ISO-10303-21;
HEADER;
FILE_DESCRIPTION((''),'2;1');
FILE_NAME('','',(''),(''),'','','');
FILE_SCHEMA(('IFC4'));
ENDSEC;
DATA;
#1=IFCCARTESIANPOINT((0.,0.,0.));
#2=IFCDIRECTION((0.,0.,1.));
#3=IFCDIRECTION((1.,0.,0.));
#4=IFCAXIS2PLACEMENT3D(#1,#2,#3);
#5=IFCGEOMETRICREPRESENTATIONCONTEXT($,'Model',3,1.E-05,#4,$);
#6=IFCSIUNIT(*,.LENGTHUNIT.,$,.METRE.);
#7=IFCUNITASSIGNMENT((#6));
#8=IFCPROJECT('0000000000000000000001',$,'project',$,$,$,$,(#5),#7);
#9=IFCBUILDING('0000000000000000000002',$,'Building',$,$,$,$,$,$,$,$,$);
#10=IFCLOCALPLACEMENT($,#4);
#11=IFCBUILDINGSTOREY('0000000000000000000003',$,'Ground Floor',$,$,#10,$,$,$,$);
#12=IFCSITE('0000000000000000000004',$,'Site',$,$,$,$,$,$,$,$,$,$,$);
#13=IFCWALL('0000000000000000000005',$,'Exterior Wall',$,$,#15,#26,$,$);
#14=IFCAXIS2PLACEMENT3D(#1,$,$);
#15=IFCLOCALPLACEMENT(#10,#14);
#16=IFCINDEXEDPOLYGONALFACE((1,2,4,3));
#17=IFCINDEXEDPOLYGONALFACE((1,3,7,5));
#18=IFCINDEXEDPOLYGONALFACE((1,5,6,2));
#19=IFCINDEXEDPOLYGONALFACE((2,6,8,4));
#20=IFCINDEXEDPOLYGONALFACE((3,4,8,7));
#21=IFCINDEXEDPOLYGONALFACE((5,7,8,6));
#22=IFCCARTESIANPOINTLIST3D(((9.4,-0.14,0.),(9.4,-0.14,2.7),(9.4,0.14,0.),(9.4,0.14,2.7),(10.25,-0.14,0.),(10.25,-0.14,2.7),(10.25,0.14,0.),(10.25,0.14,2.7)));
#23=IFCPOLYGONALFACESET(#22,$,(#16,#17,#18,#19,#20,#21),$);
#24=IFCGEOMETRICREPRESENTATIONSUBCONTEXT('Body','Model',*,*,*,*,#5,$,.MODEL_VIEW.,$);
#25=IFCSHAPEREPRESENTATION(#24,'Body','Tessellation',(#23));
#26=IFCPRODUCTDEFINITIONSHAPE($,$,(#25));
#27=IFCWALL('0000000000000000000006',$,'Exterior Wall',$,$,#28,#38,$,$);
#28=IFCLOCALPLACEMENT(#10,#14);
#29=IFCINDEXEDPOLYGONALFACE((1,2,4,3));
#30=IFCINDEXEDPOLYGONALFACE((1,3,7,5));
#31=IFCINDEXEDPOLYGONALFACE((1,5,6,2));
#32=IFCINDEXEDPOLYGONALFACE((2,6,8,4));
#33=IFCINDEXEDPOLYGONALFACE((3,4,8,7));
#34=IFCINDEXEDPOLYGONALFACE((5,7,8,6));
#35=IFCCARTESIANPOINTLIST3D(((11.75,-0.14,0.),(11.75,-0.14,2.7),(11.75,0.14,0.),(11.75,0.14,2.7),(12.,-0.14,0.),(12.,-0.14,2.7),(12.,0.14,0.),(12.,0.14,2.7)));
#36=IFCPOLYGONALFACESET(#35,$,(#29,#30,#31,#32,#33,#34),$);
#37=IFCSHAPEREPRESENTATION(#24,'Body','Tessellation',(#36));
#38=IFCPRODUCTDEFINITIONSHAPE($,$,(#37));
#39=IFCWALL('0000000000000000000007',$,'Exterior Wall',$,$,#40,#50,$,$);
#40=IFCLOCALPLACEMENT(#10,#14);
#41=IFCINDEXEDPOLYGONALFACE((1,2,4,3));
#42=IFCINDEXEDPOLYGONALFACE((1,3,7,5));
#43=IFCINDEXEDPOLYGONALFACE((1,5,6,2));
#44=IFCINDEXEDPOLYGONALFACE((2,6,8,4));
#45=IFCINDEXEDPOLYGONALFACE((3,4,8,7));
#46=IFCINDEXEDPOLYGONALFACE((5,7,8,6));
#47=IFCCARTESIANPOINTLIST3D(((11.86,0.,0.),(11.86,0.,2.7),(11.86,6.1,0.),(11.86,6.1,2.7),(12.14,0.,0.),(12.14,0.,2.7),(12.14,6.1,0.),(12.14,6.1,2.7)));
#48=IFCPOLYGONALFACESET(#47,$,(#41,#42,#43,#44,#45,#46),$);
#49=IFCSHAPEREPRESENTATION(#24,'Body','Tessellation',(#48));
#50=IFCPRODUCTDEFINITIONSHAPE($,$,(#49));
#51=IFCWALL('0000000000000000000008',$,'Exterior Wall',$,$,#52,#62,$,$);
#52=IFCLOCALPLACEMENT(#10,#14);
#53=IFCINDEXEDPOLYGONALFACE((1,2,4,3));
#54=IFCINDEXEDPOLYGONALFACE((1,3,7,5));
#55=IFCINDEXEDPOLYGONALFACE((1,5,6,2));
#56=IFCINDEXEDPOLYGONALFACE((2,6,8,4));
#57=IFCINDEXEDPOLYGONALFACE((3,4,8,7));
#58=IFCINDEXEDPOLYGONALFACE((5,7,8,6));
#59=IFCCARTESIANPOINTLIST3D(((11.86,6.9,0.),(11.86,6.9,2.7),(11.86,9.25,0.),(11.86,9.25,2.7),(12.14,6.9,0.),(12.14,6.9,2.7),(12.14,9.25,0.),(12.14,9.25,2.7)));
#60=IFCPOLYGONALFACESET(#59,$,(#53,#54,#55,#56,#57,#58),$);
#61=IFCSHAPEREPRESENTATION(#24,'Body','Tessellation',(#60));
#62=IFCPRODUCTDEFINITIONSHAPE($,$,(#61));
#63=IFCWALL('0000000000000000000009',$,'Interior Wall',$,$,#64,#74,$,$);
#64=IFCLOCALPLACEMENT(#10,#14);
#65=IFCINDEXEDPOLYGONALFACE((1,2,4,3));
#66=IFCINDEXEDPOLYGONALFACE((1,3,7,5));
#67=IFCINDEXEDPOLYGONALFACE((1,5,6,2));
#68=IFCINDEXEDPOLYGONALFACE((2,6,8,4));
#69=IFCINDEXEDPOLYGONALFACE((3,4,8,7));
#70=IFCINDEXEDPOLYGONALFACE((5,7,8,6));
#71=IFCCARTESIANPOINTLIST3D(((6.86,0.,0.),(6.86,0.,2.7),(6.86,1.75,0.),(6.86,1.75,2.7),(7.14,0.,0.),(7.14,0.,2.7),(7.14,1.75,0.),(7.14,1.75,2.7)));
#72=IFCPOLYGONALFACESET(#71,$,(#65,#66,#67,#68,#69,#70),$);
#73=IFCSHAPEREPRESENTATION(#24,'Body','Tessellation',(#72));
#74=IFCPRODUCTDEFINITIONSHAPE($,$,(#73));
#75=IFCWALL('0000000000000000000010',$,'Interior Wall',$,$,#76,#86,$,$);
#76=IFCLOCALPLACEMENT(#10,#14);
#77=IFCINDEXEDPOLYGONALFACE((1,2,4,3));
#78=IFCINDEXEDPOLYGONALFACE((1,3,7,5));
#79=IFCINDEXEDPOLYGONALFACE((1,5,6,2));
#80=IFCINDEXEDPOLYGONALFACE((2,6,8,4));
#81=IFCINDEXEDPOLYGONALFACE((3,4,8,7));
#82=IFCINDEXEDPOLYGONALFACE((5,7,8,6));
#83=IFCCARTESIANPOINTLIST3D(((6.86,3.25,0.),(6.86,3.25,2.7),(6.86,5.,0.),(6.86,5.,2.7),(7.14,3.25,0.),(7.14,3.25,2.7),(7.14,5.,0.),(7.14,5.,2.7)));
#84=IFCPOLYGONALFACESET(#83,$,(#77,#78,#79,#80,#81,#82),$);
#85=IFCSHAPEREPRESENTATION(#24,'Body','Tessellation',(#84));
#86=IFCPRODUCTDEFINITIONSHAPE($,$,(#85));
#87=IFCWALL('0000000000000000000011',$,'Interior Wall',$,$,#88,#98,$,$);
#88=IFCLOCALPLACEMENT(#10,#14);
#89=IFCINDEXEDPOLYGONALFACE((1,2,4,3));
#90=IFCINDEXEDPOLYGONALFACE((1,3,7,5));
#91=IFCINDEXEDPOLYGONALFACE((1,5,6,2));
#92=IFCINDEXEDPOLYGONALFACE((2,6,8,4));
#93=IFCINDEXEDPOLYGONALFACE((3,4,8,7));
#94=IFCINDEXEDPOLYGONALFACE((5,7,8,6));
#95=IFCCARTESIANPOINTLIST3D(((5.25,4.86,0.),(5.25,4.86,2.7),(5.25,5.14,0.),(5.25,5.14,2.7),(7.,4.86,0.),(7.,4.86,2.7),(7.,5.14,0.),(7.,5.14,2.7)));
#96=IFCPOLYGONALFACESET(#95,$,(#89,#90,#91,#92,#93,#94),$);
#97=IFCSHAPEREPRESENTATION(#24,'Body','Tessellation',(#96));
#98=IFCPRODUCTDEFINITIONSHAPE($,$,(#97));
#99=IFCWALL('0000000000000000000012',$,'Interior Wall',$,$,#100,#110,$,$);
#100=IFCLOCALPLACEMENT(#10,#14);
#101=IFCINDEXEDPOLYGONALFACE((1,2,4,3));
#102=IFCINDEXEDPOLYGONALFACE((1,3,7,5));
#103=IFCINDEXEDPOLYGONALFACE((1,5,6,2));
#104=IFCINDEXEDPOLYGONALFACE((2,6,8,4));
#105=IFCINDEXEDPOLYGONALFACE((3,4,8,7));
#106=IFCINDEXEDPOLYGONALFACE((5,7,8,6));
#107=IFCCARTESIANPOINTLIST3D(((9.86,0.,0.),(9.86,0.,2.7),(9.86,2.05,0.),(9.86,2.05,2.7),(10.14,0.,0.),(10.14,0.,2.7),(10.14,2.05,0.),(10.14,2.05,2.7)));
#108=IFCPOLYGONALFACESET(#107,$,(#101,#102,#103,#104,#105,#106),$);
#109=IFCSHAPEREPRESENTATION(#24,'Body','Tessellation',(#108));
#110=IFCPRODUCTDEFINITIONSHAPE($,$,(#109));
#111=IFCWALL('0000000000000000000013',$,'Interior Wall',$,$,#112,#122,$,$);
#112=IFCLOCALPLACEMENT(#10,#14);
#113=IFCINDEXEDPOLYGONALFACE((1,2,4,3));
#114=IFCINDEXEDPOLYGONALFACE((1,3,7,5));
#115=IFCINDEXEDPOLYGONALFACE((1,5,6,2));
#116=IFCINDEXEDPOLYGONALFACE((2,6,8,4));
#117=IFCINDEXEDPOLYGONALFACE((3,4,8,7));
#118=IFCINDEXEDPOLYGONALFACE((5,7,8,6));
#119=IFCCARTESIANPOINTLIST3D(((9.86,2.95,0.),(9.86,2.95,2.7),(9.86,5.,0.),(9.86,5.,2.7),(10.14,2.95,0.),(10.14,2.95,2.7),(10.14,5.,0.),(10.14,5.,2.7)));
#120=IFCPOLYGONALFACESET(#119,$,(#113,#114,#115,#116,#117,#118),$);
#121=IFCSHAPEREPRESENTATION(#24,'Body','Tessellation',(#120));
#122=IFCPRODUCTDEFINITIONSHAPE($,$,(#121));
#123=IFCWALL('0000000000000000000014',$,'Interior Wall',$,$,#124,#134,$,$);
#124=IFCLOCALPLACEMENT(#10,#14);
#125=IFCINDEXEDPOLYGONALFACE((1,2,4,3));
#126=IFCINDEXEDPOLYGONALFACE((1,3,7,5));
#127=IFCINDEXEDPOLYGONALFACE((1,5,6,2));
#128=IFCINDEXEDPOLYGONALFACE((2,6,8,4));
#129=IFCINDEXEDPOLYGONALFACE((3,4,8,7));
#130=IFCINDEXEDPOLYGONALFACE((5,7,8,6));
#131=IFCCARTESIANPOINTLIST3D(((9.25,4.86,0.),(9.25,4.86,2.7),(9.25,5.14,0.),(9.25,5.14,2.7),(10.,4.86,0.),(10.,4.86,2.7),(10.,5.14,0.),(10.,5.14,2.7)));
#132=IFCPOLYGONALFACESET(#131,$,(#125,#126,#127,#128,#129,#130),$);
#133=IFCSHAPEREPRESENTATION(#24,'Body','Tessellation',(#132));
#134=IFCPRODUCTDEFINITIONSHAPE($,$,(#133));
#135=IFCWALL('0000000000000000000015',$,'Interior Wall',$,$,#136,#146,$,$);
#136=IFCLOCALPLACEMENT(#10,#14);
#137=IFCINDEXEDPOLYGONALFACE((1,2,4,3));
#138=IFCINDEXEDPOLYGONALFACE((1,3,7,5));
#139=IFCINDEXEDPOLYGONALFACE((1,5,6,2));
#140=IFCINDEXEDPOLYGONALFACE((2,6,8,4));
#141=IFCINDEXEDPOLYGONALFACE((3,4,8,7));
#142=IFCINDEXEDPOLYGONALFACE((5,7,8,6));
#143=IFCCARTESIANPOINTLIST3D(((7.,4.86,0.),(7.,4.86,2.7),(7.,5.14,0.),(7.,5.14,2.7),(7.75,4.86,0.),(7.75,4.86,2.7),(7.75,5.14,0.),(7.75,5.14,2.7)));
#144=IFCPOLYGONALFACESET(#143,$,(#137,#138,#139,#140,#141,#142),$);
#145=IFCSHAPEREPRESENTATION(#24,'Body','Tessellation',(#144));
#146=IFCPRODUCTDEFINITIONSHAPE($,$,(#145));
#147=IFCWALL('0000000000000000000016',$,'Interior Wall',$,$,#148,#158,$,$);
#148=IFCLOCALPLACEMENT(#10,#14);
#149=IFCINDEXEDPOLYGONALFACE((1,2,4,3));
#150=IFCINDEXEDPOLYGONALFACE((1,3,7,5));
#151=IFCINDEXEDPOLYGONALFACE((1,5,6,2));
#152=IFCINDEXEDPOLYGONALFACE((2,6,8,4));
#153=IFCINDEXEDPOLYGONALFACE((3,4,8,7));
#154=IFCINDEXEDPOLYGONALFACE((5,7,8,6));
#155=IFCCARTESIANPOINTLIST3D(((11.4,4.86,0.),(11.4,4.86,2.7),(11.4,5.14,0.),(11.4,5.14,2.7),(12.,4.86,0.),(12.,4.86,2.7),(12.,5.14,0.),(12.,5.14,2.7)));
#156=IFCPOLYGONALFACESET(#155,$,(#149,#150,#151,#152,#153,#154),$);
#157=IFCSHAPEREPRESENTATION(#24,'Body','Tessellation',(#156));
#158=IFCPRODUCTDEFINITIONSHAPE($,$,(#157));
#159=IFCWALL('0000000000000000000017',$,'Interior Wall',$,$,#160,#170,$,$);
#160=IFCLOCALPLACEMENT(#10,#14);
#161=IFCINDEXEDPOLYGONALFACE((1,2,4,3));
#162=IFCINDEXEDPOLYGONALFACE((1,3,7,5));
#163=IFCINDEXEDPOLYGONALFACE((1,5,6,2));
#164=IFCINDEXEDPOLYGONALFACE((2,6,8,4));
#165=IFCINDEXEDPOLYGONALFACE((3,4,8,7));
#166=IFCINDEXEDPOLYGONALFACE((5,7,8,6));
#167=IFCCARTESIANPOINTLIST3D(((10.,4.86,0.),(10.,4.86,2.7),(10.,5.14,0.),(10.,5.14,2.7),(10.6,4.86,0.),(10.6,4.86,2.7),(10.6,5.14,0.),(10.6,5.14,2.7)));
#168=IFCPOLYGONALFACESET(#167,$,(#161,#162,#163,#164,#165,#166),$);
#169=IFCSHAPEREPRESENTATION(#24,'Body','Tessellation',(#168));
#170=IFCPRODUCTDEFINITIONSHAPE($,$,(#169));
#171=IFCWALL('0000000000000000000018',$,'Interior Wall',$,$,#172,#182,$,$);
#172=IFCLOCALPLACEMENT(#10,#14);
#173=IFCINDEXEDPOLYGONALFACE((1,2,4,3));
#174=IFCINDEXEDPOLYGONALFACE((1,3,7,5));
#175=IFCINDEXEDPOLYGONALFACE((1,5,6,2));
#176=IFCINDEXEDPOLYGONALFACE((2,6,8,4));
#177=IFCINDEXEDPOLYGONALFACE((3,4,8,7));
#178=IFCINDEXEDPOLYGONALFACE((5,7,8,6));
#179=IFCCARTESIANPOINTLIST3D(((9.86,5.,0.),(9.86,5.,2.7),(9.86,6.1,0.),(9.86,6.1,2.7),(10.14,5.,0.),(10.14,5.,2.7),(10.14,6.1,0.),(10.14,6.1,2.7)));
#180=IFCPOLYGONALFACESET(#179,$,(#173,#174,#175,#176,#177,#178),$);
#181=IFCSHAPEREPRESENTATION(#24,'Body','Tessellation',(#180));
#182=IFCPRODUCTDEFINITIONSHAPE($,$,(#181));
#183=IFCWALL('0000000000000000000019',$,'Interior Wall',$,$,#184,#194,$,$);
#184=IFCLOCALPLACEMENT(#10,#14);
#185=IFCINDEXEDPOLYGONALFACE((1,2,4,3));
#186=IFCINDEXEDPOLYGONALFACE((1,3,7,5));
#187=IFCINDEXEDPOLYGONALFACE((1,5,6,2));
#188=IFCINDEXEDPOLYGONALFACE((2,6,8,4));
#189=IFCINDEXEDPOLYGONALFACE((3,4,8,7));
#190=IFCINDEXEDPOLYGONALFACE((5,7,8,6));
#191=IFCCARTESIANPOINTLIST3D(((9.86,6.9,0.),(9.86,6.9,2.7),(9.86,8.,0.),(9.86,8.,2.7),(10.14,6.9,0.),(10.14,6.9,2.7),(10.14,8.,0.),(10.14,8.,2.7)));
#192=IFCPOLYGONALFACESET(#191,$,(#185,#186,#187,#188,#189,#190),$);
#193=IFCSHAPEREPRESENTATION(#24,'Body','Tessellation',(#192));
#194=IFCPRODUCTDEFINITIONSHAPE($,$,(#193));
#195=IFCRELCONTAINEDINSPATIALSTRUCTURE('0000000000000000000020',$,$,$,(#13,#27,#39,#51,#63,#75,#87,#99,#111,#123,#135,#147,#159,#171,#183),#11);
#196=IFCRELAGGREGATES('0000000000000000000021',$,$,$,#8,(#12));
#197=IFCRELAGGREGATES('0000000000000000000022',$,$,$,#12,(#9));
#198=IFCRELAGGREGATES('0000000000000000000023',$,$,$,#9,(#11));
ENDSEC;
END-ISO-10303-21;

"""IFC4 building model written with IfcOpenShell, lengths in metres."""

from ifc_helpers import new_model, si_unit, frame, origin_with_axes, place, context, subcontext, project, spatial, indexed_curve, outline, extrude, element, save


model = new_model("IFC4")

# Units and contexts
model_context = context("Model", 3, precision=1e-05, world=origin_with_axes())
body_context = subcontext(model_context, "Body", "Model", "MODEL_VIEW")
ifc_project = project(units=[si_unit("LENGTHUNIT", "METRE")], contexts=[model_context])

# Site, building, storey
site = spatial("IfcSite", under=ifc_project, Name="Site")
building = spatial("IfcBuilding", under=site, Name="Building")
storey_placement = place(None, origin_with_axes())
storey = spatial("IfcBuildingStorey", under=building, at=storey_placement, Name="Ground Floor")

# Walls
wall_1_placement = place(storey_placement, frame((9.4, 0.0, 0.0), z_axis=(0.0, 0.0, 1.0), x_axis=(1.0, 0.0, 0.0)))
element("IfcWall", 1, at=wall_1_placement, inside=storey, Name="Exterior Wall", context=body_context, shape_type="SweptSolid", body=[
    extrude(outline(indexed_curve([(0.0, 0.0), (0.0, 0.28), (0.85, 0.28), (0.85, 0.0), (0.0, 0.0)], self_intersect=False)), frame((0.0, -0.14, 0.0), z_axis=(0.0, 0.0, 1.0), x_axis=(1.0, 0.0, 0.0)), (0.0, 0.0, 1.0), 2.7),
])
wall_2_placement = place(storey_placement, frame((11.75, 0.0, 0.0), z_axis=(0.0, 0.0, 1.0), x_axis=(1.0, 0.0, 0.0)))
element("IfcWall", 2, at=wall_2_placement, inside=storey, Name="Exterior Wall", context=body_context, shape_type="SweptSolid", body=[
    extrude(outline(indexed_curve([(0.0, 0.0), (0.0, 0.28), (0.25, 0.28), (0.25, 0.0), (0.0, 0.0)], self_intersect=False)), frame((0.0, -0.14, 0.0), z_axis=(0.0, 0.0, 1.0), x_axis=(1.0, 0.0, 0.0)), (0.0, 0.0, 1.0), 2.7),
])
wall_3_placement = place(storey_placement, frame((12.0, 0.0, 0.0), z_axis=(0.0, 0.0, 1.0), x_axis=(0.0, 1.0, 0.0)))
element("IfcWall", 3, at=wall_3_placement, inside=storey, Name="Exterior Wall", context=body_context, shape_type="SweptSolid", body=[
    extrude(outline(indexed_curve([(0.0, 0.0), (0.0, 0.28), (6.1, 0.28), (6.1, 0.0), (0.0, 0.0)], self_intersect=False)), frame((0.0, -0.14, 0.0), z_axis=(0.0, 0.0, 1.0), x_axis=(1.0, 0.0, 0.0)), (0.0, 0.0, 1.0), 2.7),
])
wall_4_placement = place(storey_placement, frame((12.0, 6.9, 0.0), z_axis=(0.0, 0.0, 1.0), x_axis=(0.0, 1.0, 0.0)))
element("IfcWall", 4, at=wall_4_placement, inside=storey, Name="Exterior Wall", context=body_context, shape_type="SweptSolid", body=[
    extrude(outline(indexed_curve([(0.0, 0.0), (0.0, 0.28), (2.35, 0.28), (2.35, 0.0), (0.0, 0.0)], self_intersect=False)), frame((0.0, -0.14, 0.0), z_axis=(0.0, 0.0, 1.0), x_axis=(1.0, 0.0, 0.0)), (0.0, 0.0, 1.0), 2.7),
])
for number, where, z_axis, x_axis, name in (
    (5, (7.0, 0.0, 0.0), (0.0, 0.0, 1.0), (0.0, 1.0, 0.0), "Interior Wall"),
    (6, (7.0, 3.25, 0.0), (0.0, 0.0, 1.0), (0.0, 1.0, 0.0), "Interior Wall"),
    (7, (7.0, 5.0, 0.0), (0.0, 0.0, 1.0), (-1.0, 0.0, 0.0), "Interior Wall"),
):
    element("IfcWall", number, at=place(storey_placement, frame(where, z_axis=z_axis, x_axis=x_axis)), inside=storey, Name=name, context=body_context, shape_type="SweptSolid", body=[
        extrude(outline(indexed_curve([(0.0, 0.0), (0.0, 0.28), (1.75, 0.28), (1.75, 0.0), (0.0, 0.0)], self_intersect=False)), frame((0.0, -0.14, 0.0), z_axis=(0.0, 0.0, 1.0), x_axis=(1.0, 0.0, 0.0)), (0.0, 0.0, 1.0), 2.7),
    ])
for number, where, z_axis, x_axis, name in (
    (8, (10.0, 0.0, 0.0), (0.0, 0.0, 1.0), (0.0, 1.0, 0.0), "Interior Wall"),
    (9, (10.0, 2.95, 0.0), (0.0, 0.0, 1.0), (0.0, 1.0, 0.0), "Interior Wall"),
):
    element("IfcWall", number, at=place(storey_placement, frame(where, z_axis=z_axis, x_axis=x_axis)), inside=storey, Name=name, context=body_context, shape_type="SweptSolid", body=[
        extrude(outline(indexed_curve([(0.0, 0.0), (0.0, 0.28), (2.05, 0.28), (2.05, 0.0), (0.0, 0.0)], self_intersect=False)), frame((0.0, -0.14, 0.0), z_axis=(0.0, 0.0, 1.0), x_axis=(1.0, 0.0, 0.0)), (0.0, 0.0, 1.0), 2.7),
    ])
for number, where, z_axis, x_axis, name in (
    (10, (10.0, 5.0, 0.0), (0.0, 0.0, 1.0), (-1.0, 0.0, 0.0), "Interior Wall"),
    (11, (7.75, 5.0, 0.0), (0.0, 0.0, 1.0), (-1.0, 0.0, 0.0), "Interior Wall"),
):
    element("IfcWall", number, at=place(storey_placement, frame(where, z_axis=z_axis, x_axis=x_axis)), inside=storey, Name=name, context=body_context, shape_type="SweptSolid", body=[
        extrude(outline(indexed_curve([(0.0, 0.0), (0.0, 0.28), (0.75, 0.28), (0.75, 0.0), (0.0, 0.0)], self_intersect=False)), frame((0.0, -0.14, 0.0), z_axis=(0.0, 0.0, 1.0), x_axis=(1.0, 0.0, 0.0)), (0.0, 0.0, 1.0), 2.7),
    ])
for number, where, z_axis, x_axis, name in (
    (12, (12.0, 5.0, 0.0), (0.0, 0.0, 1.0), (-1.0, 0.0, 0.0), "Interior Wall"),
    (13, (10.6, 5.0, 0.0), (0.0, 0.0, 1.0), (-1.0, 0.0, 0.0), "Interior Wall"),
):
    element("IfcWall", number, at=place(storey_placement, frame(where, z_axis=z_axis, x_axis=x_axis)), inside=storey, Name=name, context=body_context, shape_type="SweptSolid", body=[
        extrude(outline(indexed_curve([(0.0, 0.0), (0.0, 0.28), (0.6, 0.28), (0.6, 0.0), (0.0, 0.0)], self_intersect=False)), frame((0.0, -0.14, 0.0), z_axis=(0.0, 0.0, 1.0), x_axis=(1.0, 0.0, 0.0)), (0.0, 0.0, 1.0), 2.7),
    ])
for number, where, z_axis, x_axis, name in (
    (14, (10.0, 5.0, 0.0), (0.0, 0.0, 1.0), (0.0, 1.0, 0.0), "Interior Wall"),
    (15, (10.0, 6.9, 0.0), (0.0, 0.0, 1.0), (0.0, 1.0, 0.0), "Interior Wall"),
):
    element("IfcWall", number, at=place(storey_placement, frame(where, z_axis=z_axis, x_axis=x_axis)), inside=storey, Name=name, context=body_context, shape_type="SweptSolid", body=[
        extrude(outline(indexed_curve([(0.0, 0.0), (0.0, 0.28), (1.1, 0.28), (1.1, 0.0), (0.0, 0.0)], self_intersect=False)), frame((0.0, -0.14, 0.0), z_axis=(0.0, 0.0, 1.0), x_axis=(1.0, 0.0, 0.0)), (0.0, 0.0, 1.0), 2.7),
    ])

save(model, "model.ifc")
